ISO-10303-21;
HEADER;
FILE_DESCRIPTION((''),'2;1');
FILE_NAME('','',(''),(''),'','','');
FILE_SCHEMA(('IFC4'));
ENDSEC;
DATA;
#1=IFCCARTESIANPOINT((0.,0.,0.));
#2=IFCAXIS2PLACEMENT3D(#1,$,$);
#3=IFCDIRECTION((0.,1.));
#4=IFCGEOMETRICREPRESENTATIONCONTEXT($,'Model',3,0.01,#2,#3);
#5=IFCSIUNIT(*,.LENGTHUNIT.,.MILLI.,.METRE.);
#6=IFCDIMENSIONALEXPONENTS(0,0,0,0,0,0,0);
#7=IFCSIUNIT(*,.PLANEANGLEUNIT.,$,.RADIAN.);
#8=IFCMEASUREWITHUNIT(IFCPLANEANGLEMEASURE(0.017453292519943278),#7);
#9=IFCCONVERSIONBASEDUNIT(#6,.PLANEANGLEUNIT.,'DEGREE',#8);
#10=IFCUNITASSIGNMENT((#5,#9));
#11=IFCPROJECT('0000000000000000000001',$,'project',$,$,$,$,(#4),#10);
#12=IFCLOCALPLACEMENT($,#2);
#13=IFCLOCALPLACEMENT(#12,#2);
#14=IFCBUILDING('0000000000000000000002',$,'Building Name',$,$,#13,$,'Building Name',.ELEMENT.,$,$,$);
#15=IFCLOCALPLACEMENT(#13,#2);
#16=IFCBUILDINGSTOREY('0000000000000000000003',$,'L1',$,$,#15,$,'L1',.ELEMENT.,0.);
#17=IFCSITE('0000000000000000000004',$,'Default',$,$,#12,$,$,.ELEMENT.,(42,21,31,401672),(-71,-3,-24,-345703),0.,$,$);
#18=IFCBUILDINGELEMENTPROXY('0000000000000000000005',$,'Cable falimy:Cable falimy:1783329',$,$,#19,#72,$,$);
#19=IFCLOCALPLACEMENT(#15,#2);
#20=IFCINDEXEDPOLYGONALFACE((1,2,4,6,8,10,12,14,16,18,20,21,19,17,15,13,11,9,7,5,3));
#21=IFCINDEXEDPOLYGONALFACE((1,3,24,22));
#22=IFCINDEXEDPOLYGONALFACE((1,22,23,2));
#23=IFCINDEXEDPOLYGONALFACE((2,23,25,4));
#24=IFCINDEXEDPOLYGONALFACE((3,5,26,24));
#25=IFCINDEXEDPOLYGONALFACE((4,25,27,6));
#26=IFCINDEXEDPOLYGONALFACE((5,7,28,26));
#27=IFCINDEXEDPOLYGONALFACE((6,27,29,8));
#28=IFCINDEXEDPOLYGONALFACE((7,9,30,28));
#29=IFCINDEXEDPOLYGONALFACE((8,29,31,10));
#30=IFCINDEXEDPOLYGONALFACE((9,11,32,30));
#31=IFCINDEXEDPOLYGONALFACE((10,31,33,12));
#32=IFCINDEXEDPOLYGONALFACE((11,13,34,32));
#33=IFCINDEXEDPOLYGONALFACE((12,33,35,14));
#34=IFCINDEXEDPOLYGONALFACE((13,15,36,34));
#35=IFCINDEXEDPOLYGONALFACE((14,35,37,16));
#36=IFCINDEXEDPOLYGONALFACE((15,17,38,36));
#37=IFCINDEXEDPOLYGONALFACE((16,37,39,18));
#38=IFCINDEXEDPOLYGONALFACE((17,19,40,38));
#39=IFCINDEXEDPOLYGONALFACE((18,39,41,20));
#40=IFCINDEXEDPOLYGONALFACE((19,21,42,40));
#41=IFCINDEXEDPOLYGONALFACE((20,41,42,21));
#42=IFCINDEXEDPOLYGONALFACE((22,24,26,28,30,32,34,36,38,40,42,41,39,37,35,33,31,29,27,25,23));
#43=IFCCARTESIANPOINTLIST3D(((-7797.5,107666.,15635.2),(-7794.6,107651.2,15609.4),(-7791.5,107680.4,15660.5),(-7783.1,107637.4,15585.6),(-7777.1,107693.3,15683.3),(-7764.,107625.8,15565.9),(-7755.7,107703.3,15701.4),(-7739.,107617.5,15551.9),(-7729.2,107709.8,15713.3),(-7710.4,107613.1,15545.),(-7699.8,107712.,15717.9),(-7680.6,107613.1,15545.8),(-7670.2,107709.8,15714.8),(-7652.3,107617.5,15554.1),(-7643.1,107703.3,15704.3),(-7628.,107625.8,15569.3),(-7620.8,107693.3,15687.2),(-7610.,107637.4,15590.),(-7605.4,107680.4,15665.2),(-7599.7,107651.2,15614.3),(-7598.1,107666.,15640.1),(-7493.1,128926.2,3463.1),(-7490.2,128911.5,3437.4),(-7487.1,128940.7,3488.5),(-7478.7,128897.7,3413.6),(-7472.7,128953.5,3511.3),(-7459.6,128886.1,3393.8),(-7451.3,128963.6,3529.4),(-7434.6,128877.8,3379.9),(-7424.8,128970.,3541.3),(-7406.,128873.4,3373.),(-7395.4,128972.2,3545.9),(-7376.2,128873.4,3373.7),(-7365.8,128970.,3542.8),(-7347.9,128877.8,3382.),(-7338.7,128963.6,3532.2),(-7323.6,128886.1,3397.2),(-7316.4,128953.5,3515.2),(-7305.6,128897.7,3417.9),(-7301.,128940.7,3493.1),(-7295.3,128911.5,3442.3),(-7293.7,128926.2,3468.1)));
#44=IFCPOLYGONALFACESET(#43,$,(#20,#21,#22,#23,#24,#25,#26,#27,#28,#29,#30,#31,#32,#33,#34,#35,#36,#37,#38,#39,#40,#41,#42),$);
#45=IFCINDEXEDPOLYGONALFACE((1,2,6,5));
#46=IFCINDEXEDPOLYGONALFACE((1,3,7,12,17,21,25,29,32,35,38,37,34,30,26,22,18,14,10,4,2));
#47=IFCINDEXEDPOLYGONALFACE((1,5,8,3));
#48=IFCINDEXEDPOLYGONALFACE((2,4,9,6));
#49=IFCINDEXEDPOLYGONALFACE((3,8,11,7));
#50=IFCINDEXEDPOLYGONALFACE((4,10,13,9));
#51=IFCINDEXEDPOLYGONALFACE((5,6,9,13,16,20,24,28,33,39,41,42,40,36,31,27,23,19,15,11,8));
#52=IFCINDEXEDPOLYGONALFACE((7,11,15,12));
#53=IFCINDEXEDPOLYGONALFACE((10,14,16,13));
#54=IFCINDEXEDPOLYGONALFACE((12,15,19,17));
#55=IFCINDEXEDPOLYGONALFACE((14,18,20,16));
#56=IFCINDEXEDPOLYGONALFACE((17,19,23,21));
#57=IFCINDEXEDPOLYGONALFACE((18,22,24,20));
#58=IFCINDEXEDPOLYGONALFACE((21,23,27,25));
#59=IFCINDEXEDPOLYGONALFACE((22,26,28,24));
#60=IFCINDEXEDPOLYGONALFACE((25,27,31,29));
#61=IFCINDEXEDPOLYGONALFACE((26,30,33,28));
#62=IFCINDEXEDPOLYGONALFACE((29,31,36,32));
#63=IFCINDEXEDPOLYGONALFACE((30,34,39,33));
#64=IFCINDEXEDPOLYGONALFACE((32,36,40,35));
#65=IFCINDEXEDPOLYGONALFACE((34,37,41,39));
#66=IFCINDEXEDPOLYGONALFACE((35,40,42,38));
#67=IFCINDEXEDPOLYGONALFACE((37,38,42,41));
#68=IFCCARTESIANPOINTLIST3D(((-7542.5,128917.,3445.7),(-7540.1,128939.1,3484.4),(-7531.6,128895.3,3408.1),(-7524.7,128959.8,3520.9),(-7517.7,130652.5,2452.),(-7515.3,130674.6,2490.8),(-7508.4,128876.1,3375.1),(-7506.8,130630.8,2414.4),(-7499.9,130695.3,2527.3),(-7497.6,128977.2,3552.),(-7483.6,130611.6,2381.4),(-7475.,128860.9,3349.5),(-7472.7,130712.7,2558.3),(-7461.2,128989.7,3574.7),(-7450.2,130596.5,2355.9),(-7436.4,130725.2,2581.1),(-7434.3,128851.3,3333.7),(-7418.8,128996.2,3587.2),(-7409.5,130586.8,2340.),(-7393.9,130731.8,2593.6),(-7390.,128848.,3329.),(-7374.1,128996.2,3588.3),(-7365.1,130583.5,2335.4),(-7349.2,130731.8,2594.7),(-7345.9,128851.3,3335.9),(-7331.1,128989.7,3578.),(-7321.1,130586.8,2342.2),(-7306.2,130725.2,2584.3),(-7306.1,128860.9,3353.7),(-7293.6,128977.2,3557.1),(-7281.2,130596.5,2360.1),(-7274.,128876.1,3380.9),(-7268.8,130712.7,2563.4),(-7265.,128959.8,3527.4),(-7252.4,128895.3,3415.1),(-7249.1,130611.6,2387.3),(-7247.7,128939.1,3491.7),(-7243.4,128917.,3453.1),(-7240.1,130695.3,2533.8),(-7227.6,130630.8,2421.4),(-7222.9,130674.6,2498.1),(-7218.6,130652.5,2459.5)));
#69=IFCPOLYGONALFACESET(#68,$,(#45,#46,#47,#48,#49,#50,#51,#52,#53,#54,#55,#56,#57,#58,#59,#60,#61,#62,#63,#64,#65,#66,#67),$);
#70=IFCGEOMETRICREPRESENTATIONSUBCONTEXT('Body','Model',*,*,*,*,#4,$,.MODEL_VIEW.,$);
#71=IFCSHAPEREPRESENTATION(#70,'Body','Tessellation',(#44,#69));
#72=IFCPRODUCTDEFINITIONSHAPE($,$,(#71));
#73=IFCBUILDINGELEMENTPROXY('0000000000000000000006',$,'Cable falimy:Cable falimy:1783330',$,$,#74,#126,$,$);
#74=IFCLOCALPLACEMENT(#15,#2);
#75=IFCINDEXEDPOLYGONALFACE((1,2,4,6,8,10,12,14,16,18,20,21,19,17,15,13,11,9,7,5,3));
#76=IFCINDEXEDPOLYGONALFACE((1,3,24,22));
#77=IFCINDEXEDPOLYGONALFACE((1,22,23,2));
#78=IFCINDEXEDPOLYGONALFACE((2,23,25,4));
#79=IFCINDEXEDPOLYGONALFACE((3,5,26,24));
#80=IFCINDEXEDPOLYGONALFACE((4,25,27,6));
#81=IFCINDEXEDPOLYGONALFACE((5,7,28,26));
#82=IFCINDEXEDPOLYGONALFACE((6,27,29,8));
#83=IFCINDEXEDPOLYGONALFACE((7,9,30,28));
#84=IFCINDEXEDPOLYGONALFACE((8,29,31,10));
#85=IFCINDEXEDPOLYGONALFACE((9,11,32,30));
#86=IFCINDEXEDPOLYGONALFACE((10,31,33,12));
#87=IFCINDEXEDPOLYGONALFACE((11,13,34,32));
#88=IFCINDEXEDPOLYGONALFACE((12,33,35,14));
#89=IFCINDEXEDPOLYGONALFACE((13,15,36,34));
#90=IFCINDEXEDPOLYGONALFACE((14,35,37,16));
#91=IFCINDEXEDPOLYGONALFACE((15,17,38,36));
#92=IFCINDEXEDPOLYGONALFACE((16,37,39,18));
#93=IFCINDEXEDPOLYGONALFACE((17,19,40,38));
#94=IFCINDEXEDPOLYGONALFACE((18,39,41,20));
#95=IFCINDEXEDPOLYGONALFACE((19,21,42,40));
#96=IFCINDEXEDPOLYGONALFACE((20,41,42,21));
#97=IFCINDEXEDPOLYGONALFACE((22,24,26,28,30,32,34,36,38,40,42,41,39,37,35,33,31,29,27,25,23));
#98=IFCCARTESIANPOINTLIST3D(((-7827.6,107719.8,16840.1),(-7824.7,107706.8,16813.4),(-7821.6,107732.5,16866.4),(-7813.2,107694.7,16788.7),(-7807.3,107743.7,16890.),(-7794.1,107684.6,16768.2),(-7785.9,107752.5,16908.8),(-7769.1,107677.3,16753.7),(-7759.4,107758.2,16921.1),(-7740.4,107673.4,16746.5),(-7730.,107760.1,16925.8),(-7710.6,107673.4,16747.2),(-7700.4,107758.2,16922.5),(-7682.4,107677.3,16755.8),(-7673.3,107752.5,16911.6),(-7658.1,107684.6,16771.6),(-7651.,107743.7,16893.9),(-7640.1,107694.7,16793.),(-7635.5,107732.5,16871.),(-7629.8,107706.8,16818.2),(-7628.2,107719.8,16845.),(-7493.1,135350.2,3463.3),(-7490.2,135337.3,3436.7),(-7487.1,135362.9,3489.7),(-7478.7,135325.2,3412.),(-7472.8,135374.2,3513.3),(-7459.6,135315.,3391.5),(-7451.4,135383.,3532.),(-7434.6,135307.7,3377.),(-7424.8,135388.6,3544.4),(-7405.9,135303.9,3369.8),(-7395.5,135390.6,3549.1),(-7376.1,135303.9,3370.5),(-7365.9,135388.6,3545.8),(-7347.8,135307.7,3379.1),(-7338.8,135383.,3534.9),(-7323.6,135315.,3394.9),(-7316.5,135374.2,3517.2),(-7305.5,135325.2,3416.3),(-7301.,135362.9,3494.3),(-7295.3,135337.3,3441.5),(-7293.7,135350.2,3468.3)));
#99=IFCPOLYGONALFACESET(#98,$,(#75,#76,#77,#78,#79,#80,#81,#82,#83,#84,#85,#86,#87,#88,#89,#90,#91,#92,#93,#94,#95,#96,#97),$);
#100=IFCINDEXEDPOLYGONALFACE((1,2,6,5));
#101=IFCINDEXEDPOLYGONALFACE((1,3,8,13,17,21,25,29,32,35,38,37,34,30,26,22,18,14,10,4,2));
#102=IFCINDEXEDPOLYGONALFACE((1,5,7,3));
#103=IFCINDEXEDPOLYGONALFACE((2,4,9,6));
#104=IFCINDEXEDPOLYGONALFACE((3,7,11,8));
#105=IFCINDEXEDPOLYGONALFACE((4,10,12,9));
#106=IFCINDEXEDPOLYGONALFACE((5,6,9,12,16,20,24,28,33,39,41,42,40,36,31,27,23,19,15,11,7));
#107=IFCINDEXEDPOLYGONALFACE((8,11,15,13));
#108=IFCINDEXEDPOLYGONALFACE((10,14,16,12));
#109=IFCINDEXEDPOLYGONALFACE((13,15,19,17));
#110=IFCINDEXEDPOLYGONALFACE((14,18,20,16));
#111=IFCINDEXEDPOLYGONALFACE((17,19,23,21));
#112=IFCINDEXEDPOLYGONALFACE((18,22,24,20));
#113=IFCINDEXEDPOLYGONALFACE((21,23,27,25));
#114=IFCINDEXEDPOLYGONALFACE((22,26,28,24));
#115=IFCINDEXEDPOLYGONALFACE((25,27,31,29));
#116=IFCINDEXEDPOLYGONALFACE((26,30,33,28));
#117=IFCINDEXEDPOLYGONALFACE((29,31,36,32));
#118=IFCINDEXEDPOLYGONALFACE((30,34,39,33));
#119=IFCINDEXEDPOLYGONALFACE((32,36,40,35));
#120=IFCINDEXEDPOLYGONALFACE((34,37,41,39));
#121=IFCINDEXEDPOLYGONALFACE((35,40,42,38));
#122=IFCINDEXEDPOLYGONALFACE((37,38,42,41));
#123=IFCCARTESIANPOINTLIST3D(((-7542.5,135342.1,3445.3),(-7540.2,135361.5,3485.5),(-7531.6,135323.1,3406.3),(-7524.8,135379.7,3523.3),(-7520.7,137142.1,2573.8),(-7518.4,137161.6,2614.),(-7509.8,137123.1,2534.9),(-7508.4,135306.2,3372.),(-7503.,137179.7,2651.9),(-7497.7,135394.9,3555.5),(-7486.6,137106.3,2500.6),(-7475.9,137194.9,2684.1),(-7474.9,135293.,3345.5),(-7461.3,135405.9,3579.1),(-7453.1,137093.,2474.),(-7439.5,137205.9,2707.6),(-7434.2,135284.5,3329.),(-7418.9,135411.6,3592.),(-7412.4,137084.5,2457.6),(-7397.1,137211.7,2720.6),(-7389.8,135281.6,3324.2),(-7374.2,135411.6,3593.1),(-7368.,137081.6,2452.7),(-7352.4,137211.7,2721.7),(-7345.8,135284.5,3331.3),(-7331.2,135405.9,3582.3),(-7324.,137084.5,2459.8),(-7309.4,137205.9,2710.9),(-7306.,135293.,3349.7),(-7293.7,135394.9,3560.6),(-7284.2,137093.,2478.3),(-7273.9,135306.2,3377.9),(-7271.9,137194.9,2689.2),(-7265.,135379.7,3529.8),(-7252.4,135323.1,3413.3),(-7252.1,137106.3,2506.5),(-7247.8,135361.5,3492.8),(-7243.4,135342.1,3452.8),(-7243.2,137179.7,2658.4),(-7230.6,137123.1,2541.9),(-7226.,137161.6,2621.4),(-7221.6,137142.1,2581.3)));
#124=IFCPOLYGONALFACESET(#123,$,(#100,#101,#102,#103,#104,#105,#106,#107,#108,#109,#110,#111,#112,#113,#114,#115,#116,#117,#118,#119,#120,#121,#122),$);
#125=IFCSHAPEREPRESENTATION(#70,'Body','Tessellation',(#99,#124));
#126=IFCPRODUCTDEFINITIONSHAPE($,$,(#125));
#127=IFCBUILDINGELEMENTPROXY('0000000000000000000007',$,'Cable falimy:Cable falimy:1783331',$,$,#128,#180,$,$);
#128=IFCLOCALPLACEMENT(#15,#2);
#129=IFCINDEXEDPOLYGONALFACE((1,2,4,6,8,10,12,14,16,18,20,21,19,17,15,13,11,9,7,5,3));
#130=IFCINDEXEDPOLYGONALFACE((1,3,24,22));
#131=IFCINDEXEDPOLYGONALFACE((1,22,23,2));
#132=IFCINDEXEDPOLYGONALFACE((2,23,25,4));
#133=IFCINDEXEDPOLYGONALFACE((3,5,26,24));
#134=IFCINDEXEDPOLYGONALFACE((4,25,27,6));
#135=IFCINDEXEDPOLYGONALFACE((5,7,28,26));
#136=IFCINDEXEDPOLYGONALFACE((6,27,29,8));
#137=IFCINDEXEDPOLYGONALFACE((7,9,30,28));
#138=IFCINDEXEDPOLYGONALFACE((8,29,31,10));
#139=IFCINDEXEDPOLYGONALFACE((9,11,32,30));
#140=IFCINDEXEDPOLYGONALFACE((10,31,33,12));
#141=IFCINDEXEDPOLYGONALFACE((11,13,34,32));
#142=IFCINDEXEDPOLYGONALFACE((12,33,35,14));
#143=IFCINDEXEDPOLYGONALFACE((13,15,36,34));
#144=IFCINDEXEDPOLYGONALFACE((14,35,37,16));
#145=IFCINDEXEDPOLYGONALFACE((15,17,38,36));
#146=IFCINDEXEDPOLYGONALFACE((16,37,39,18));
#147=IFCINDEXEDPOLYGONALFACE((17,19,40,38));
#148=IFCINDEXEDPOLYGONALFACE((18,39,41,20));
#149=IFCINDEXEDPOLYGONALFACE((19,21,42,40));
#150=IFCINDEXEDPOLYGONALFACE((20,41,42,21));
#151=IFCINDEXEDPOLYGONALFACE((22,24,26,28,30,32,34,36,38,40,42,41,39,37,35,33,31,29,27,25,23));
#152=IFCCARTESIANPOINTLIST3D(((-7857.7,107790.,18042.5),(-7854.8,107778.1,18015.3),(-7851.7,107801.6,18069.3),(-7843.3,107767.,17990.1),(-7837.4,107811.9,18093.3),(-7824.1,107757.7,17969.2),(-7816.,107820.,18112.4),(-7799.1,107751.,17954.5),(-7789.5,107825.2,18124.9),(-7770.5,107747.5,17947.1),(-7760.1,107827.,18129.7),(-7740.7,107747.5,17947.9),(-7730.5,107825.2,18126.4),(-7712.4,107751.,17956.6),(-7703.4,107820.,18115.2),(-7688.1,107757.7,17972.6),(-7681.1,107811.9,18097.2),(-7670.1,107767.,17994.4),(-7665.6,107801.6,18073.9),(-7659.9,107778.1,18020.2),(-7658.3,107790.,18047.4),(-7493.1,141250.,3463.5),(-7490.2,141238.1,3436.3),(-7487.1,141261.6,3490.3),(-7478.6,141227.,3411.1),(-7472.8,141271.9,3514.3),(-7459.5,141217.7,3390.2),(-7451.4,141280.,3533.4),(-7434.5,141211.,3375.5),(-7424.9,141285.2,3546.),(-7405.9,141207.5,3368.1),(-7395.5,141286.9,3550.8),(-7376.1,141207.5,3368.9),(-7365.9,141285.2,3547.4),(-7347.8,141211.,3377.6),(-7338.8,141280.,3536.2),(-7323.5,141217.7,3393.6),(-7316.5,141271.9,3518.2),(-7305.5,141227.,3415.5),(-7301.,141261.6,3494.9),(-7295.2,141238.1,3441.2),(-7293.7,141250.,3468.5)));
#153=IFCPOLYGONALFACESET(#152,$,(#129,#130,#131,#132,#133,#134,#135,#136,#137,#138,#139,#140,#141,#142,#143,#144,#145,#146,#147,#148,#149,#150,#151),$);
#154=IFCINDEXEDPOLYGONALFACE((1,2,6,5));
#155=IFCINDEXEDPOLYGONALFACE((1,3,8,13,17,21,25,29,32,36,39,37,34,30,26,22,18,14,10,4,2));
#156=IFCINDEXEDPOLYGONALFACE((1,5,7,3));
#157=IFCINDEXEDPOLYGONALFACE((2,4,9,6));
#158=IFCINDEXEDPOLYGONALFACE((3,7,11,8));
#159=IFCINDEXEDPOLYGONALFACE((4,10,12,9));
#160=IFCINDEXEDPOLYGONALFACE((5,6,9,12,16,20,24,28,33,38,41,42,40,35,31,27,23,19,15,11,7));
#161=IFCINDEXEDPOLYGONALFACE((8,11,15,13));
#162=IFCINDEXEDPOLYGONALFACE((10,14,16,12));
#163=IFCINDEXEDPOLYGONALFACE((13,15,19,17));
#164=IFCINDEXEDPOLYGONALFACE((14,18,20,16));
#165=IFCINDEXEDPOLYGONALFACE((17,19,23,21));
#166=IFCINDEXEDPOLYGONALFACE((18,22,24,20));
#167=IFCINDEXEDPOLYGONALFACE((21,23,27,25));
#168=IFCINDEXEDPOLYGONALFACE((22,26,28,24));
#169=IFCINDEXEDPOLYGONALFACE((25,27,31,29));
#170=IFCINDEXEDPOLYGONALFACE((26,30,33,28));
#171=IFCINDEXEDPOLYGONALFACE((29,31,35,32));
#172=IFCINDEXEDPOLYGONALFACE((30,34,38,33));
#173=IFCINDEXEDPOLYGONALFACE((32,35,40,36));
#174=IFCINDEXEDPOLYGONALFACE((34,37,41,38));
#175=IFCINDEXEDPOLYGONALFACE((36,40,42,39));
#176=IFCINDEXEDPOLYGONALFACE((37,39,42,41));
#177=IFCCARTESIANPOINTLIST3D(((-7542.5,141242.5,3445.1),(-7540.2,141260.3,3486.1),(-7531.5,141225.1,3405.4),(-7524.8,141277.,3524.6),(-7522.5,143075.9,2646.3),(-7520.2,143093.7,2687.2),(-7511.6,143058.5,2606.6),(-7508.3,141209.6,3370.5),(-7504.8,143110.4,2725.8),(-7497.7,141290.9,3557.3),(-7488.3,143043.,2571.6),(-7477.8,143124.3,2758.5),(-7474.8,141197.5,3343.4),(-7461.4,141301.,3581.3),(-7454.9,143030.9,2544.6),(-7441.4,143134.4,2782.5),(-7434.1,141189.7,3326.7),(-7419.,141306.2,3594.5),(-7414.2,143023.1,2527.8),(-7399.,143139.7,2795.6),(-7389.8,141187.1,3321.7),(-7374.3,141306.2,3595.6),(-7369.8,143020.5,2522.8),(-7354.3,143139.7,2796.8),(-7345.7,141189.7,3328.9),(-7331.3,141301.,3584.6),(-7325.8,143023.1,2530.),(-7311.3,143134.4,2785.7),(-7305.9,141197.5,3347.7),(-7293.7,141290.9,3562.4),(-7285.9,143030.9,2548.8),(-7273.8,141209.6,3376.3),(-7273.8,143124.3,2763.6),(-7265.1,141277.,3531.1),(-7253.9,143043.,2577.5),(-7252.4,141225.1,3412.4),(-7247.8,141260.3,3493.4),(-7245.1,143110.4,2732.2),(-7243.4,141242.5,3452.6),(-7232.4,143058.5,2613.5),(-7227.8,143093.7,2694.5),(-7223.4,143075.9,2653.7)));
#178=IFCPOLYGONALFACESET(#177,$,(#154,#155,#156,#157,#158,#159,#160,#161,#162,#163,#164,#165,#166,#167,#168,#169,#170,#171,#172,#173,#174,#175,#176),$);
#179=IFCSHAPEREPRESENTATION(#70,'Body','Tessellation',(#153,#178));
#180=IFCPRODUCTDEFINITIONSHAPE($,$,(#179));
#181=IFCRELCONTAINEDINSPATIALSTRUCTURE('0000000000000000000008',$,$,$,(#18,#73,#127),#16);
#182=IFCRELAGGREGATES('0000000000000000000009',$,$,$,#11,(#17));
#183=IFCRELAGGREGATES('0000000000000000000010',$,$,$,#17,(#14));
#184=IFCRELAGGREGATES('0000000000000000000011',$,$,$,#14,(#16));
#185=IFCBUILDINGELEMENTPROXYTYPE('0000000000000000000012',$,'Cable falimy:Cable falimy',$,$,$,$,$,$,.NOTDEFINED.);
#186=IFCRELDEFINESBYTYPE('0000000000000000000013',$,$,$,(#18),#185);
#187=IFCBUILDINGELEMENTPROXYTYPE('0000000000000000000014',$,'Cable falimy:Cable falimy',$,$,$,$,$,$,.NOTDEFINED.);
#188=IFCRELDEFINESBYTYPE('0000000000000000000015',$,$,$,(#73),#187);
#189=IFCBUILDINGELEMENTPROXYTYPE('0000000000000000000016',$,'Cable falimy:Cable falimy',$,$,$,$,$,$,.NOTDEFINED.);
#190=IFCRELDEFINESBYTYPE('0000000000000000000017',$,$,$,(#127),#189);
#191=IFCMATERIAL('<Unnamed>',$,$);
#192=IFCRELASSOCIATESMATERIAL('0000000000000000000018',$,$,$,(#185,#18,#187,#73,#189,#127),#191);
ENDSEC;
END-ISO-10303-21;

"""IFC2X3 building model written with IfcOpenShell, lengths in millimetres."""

from ifc_helpers import new_model, entity, si_unit, converted_unit, direction, frame, frame_2d, origin, place, context, subcontext, project, spatial, circle, extrude, source, transform, mapped, material, type_object, type_shapes, element, save


model = new_model("IFC2X3")

# Units and contexts
model_context = context("Model", 3, precision=0.01, world=origin(), true_north=direction((0.0, 1.0)))
body_context = subcontext(model_context, "Body", "Model", "MODEL_VIEW")
ifc_project = project(units=[si_unit("LENGTHUNIT", "METRE", prefix="MILLI"), converted_unit("PLANEANGLEUNIT", "DEGREE", entity("IfcPlaneAngleMeasure", 0.017453292519943278), si_unit("PLANEANGLEUNIT", "RADIAN"), dimensions=[0, 0, 0, 0, 0, 0, 0])], contexts=[model_context])

# Site, building, storey
site_placement = place(None, origin())
site = spatial("IfcSite", under=ifc_project, at=site_placement, Name="Default", CompositionType="ELEMENT", RefLatitude=(42, 21, 31, 401672), RefLongitude=(-71, -3, -24, -345703), RefElevation=0.0)
building_placement = place(site_placement, origin())
building = spatial("IfcBuilding", under=site, at=building_placement, Name="Building Name", LongName="Building Name", CompositionType="ELEMENT")
storey_placement = place(building_placement, origin())
storey = spatial("IfcBuildingStorey", under=building, at=storey_placement, Name="L1", LongName="L1", CompositionType="ELEMENT", Elevation=0.0)

# Shared definitions
ifc_material = material(Name="<Unnamed>")

# Building element proxies
building_element_proxy_type_1 = type_object("IfcBuildingElementProxyType", Name="Cable falimy:Cable falimy", PredefinedType="NOTDEFINED", material=ifc_material)
shared_shape_1 = source(origin(), body_context, "Body", "SweptSolid", [
    extrude(circle(Radius=100.0, at=frame_2d((0.0, 0.0), x_axis=(1.0, 0.0))), frame((0.0, 0.0, 0.0), z_axis=(0.867765, 0.0, 0.496974), x_axis=(-0.496974, 0.0, 0.867765)), (0.0, 0.0, 1.0), 24500.0),
    extrude(circle(Radius=150.0, at=frame_2d((0.0, 0.0), x_axis=(1.0, 0.0))), frame((-1735.5, 0.0, -993.9), z_axis=(0.867765, 0.0, 0.496974), x_axis=(0.496974, 0.0, -0.867765)), (0.0, 0.0, 1.0), 2000.0),
])
type_shapes(building_element_proxy_type_1, [shared_shape_1])
proxy_1_placement = place(storey_placement, frame((-7393.2, 128922.5, 3459.1), z_axis=(-0.025001, 0.0, 0.999687), x_axis=(0.0, -1.0, 0.0)))
element("IfcBuildingElementProxy", 1, at=proxy_1_placement, inside=storey, type_object=building_element_proxy_type_1, material=ifc_material, Name="Cable falimy:Cable falimy:1783329", context=body_context, shape_type="MappedRepresentation", body=[
    mapped(shared_shape_1, transform((0.0, 0.0, 0.0), scale=1.0)),
])
building_element_proxy_type_2 = type_object("IfcBuildingElementProxyType", Name="Cable falimy:Cable falimy", PredefinedType="NOTDEFINED", material=ifc_material)
shared_shape_2 = source(origin(), body_context, "Body", "SweptSolid", [
    extrude(circle(Radius=100.0, at=frame_2d((0.0, 0.0), x_axis=(1.0, 0.0))), frame((0.0, 0.0, 0.0), z_axis=(0.900015, 0.0, 0.43586), x_axis=(-0.43586, 0.0, 0.900015)), (0.0, 0.0, 1.0), 30700.0),
    extrude(circle(Radius=150.0, at=frame_2d((0.0, 0.0), x_axis=(1.0, 0.0))), frame((-1800.0, 0.0, -871.7), z_axis=(0.900015, 0.0, 0.43586), x_axis=(0.43586, 0.0, -0.900015)), (0.0, 0.0, 1.0), 2000.0),
])
type_shapes(building_element_proxy_type_2, [shared_shape_2])
proxy_2_placement = place(storey_placement, frame((-7393.2, 135347.0, 3459.1), z_axis=(-0.025001, 0.0, 0.999687), x_axis=(0.0, -1.0, 0.0)))
element("IfcBuildingElementProxy", 2, at=proxy_2_placement, inside=storey, type_object=building_element_proxy_type_2, material=ifc_material, Name="Cable falimy:Cable falimy:1783330", context=body_context, shape_type="MappedRepresentation", body=[
    mapped(shared_shape_2, transform((0.0, 0.0, 0.0), scale=1.0)),
])
building_element_proxy_type_3 = type_object("IfcBuildingElementProxyType", Name="Cable falimy:Cable falimy", PredefinedType="NOTDEFINED", material=ifc_material)
shared_shape_3 = source(origin(), body_context, "Body", "SweptSolid", [
    extrude(circle(Radius=100.0, at=frame_2d((0.0, 0.0), x_axis=(1.0, 0.0))), frame((0.0, 0.0, 0.0), z_axis=(0.916712, 0.0, 0.399549), x_axis=(-0.399549, 0.0, 0.916712)), (0.0, 0.0, 1.0), 36500.0),
    extrude(circle(Radius=150.0, at=frame_2d((0.0, 0.0), x_axis=(1.0, 0.0))), frame((-1833.4, 0.0, -799.1), z_axis=(0.916712, 0.0, 0.399549), x_axis=(0.399549, 0.0, -0.916712)), (0.0, 0.0, 1.0), 2000.0),
])
type_shapes(building_element_proxy_type_3, [shared_shape_3])
proxy_3_placement = place(storey_placement, frame((-7393.2, 141247.0, 3459.1), z_axis=(-0.025001, 0.0, 0.999687), x_axis=(0.0, -1.0, 0.0)))
element("IfcBuildingElementProxy", 3, at=proxy_3_placement, inside=storey, type_object=building_element_proxy_type_3, material=ifc_material, Name="Cable falimy:Cable falimy:1783331", context=body_context, shape_type="MappedRepresentation", body=[
    mapped(shared_shape_3, transform((0.0, 0.0, 0.0), scale=1.0)),
])

save(model, "model.ifc")
